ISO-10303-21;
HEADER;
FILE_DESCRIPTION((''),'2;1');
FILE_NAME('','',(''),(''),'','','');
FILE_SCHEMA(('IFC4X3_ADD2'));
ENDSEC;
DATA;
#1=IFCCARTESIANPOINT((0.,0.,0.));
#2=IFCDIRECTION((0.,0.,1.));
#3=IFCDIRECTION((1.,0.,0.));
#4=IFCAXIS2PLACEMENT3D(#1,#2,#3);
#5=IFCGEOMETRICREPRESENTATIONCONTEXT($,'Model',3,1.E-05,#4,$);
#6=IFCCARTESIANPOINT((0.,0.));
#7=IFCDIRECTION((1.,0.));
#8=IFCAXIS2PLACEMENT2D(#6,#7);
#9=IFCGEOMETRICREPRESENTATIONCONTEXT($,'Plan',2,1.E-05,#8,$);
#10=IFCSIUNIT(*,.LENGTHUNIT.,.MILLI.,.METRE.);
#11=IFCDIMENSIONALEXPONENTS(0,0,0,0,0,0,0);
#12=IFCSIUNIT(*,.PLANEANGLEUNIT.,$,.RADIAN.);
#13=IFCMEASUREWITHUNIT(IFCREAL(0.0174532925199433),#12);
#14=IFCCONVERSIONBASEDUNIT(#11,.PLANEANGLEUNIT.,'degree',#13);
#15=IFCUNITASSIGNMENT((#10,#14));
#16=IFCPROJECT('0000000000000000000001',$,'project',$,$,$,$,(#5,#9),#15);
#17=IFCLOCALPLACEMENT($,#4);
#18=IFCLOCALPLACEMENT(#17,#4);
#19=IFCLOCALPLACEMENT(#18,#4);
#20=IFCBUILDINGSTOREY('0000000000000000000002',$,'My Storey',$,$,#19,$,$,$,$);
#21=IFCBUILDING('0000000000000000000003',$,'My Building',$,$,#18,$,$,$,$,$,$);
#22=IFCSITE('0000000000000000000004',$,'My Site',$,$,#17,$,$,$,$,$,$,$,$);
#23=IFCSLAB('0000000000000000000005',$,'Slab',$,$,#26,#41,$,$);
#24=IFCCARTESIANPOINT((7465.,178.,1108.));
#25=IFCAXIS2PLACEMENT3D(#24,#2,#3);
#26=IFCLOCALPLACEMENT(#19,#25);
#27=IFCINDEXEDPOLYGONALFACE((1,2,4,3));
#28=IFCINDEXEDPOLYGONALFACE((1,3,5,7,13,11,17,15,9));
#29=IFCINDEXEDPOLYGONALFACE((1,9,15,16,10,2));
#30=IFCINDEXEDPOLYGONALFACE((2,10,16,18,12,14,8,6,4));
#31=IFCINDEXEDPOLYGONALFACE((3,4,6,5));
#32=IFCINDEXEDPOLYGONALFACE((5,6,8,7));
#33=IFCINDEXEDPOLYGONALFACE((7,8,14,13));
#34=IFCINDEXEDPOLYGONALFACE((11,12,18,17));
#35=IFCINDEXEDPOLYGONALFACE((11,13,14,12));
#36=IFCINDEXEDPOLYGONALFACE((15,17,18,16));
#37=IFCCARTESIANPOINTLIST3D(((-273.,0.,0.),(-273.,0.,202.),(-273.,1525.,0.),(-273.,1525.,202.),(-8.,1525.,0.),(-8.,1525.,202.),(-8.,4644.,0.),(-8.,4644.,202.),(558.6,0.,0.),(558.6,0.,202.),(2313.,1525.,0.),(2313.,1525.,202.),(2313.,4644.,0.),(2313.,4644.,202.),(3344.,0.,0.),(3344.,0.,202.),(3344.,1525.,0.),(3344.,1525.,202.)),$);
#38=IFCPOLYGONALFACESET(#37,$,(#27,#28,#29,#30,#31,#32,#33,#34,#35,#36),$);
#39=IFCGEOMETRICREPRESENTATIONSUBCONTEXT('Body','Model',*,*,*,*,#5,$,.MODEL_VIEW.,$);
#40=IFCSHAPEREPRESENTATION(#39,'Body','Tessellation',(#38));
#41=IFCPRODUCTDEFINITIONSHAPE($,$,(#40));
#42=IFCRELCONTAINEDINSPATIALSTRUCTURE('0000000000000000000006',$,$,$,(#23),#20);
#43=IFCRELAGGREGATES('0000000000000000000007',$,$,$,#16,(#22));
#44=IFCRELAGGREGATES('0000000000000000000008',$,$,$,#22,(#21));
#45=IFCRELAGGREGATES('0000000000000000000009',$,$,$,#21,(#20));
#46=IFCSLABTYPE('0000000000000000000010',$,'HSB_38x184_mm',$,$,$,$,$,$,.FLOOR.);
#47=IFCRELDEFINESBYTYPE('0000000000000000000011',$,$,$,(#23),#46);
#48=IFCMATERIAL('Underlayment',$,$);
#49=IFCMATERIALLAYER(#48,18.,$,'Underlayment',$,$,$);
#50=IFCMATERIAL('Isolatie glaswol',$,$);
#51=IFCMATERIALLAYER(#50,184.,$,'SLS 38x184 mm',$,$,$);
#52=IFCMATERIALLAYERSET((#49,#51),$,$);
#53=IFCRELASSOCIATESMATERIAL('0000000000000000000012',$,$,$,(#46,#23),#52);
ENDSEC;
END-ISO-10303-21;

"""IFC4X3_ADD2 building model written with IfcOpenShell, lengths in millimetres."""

from ifc_helpers import new_model, entity, si_unit, converted_unit, frame, origin_with_axes, origin_2d_with_axis, place, context, subcontext, project, spatial, line, indexed_curve, outline, extrude, material, layer, layer_set, layer_usage, type_object, element, save


model = new_model("IFC4X3_ADD2")

# Units and contexts
model_context = context("Model", 3, precision=1e-05, world=origin_with_axes())
plan_context = context("Plan", 2, precision=1e-05, world=origin_2d_with_axis())
body_context_1 = subcontext(model_context, "Body", "Model", "MODEL_VIEW")
ifc_project = project(units=[si_unit("LENGTHUNIT", "METRE", prefix="MILLI"), converted_unit("PLANEANGLEUNIT", "degree", entity("IfcReal", 0.0174532925199433), si_unit("PLANEANGLEUNIT", "RADIAN"), dimensions=[0, 0, 0, 0, 0, 0, 0])], contexts=[model_context, plan_context])

# Site, building, storey
site_placement = place(None, origin_with_axes())
site = spatial("IfcSite", under=ifc_project, at=site_placement, Name="My Site")
building_placement = place(site_placement, origin_with_axes())
building = spatial("IfcBuilding", under=site, at=building_placement, Name="My Building")
storey_placement = place(building_placement, origin_with_axes())
storey = spatial("IfcBuildingStorey", under=building, at=storey_placement, Name="My Storey")

# Slab
ifc_material_1 = material(Name="Underlayment")
ifc_layer_1 = layer(ifc_material_1, 18.0, Name="Underlayment")
ifc_material_2 = material(Name="Isolatie glaswol")
ifc_layer_2 = layer(ifc_material_2, 184.0, Name="SLS 38x184 mm")
ifc_layer_set_1 = layer_set([ifc_layer_1, ifc_layer_2])
ifc_layer_usage_1 = layer_usage(ifc_layer_set_1, "AXIS3", "POSITIVE", 0.0)
slab_type_1 = type_object("IfcSlabType", Name="HSB_38x184_mm", PredefinedType="FLOOR", material=ifc_layer_set_1)
slab_1_placement = place(storey_placement, frame((7465.0, 178.0, 1108.0), z_axis=(0.0, 0.0, 1.0), x_axis=(1.0, 0.0, 0.0)))
element("IfcSlab", 1, at=slab_1_placement, inside=storey, type_object=slab_type_1, material=ifc_layer_usage_1, Name="Slab", context=body_context_1, shape_type="SweptSolid", body=[
    extrude(outline(indexed_curve([(-8.0, 4644.0), (-8.0, 1525.0), (-273.0, 1525.0), (-273.0, 0.0), (558.6, 0.0), (3344.0, 0.0), (3344.0, 1525.0), (2313.0, 1525.0), (2313.0, 4644.0)], segments=[line(3, 2), line(2, 1), line(1, 9), line(9, 8), line(8, 7), line(7, 6), line(6, 5), line(5, 4), line(4, 3)], self_intersect=False)), None, (0.0, 0.0, 1.0), 202.0),
])

save(model, "model.ifc")
